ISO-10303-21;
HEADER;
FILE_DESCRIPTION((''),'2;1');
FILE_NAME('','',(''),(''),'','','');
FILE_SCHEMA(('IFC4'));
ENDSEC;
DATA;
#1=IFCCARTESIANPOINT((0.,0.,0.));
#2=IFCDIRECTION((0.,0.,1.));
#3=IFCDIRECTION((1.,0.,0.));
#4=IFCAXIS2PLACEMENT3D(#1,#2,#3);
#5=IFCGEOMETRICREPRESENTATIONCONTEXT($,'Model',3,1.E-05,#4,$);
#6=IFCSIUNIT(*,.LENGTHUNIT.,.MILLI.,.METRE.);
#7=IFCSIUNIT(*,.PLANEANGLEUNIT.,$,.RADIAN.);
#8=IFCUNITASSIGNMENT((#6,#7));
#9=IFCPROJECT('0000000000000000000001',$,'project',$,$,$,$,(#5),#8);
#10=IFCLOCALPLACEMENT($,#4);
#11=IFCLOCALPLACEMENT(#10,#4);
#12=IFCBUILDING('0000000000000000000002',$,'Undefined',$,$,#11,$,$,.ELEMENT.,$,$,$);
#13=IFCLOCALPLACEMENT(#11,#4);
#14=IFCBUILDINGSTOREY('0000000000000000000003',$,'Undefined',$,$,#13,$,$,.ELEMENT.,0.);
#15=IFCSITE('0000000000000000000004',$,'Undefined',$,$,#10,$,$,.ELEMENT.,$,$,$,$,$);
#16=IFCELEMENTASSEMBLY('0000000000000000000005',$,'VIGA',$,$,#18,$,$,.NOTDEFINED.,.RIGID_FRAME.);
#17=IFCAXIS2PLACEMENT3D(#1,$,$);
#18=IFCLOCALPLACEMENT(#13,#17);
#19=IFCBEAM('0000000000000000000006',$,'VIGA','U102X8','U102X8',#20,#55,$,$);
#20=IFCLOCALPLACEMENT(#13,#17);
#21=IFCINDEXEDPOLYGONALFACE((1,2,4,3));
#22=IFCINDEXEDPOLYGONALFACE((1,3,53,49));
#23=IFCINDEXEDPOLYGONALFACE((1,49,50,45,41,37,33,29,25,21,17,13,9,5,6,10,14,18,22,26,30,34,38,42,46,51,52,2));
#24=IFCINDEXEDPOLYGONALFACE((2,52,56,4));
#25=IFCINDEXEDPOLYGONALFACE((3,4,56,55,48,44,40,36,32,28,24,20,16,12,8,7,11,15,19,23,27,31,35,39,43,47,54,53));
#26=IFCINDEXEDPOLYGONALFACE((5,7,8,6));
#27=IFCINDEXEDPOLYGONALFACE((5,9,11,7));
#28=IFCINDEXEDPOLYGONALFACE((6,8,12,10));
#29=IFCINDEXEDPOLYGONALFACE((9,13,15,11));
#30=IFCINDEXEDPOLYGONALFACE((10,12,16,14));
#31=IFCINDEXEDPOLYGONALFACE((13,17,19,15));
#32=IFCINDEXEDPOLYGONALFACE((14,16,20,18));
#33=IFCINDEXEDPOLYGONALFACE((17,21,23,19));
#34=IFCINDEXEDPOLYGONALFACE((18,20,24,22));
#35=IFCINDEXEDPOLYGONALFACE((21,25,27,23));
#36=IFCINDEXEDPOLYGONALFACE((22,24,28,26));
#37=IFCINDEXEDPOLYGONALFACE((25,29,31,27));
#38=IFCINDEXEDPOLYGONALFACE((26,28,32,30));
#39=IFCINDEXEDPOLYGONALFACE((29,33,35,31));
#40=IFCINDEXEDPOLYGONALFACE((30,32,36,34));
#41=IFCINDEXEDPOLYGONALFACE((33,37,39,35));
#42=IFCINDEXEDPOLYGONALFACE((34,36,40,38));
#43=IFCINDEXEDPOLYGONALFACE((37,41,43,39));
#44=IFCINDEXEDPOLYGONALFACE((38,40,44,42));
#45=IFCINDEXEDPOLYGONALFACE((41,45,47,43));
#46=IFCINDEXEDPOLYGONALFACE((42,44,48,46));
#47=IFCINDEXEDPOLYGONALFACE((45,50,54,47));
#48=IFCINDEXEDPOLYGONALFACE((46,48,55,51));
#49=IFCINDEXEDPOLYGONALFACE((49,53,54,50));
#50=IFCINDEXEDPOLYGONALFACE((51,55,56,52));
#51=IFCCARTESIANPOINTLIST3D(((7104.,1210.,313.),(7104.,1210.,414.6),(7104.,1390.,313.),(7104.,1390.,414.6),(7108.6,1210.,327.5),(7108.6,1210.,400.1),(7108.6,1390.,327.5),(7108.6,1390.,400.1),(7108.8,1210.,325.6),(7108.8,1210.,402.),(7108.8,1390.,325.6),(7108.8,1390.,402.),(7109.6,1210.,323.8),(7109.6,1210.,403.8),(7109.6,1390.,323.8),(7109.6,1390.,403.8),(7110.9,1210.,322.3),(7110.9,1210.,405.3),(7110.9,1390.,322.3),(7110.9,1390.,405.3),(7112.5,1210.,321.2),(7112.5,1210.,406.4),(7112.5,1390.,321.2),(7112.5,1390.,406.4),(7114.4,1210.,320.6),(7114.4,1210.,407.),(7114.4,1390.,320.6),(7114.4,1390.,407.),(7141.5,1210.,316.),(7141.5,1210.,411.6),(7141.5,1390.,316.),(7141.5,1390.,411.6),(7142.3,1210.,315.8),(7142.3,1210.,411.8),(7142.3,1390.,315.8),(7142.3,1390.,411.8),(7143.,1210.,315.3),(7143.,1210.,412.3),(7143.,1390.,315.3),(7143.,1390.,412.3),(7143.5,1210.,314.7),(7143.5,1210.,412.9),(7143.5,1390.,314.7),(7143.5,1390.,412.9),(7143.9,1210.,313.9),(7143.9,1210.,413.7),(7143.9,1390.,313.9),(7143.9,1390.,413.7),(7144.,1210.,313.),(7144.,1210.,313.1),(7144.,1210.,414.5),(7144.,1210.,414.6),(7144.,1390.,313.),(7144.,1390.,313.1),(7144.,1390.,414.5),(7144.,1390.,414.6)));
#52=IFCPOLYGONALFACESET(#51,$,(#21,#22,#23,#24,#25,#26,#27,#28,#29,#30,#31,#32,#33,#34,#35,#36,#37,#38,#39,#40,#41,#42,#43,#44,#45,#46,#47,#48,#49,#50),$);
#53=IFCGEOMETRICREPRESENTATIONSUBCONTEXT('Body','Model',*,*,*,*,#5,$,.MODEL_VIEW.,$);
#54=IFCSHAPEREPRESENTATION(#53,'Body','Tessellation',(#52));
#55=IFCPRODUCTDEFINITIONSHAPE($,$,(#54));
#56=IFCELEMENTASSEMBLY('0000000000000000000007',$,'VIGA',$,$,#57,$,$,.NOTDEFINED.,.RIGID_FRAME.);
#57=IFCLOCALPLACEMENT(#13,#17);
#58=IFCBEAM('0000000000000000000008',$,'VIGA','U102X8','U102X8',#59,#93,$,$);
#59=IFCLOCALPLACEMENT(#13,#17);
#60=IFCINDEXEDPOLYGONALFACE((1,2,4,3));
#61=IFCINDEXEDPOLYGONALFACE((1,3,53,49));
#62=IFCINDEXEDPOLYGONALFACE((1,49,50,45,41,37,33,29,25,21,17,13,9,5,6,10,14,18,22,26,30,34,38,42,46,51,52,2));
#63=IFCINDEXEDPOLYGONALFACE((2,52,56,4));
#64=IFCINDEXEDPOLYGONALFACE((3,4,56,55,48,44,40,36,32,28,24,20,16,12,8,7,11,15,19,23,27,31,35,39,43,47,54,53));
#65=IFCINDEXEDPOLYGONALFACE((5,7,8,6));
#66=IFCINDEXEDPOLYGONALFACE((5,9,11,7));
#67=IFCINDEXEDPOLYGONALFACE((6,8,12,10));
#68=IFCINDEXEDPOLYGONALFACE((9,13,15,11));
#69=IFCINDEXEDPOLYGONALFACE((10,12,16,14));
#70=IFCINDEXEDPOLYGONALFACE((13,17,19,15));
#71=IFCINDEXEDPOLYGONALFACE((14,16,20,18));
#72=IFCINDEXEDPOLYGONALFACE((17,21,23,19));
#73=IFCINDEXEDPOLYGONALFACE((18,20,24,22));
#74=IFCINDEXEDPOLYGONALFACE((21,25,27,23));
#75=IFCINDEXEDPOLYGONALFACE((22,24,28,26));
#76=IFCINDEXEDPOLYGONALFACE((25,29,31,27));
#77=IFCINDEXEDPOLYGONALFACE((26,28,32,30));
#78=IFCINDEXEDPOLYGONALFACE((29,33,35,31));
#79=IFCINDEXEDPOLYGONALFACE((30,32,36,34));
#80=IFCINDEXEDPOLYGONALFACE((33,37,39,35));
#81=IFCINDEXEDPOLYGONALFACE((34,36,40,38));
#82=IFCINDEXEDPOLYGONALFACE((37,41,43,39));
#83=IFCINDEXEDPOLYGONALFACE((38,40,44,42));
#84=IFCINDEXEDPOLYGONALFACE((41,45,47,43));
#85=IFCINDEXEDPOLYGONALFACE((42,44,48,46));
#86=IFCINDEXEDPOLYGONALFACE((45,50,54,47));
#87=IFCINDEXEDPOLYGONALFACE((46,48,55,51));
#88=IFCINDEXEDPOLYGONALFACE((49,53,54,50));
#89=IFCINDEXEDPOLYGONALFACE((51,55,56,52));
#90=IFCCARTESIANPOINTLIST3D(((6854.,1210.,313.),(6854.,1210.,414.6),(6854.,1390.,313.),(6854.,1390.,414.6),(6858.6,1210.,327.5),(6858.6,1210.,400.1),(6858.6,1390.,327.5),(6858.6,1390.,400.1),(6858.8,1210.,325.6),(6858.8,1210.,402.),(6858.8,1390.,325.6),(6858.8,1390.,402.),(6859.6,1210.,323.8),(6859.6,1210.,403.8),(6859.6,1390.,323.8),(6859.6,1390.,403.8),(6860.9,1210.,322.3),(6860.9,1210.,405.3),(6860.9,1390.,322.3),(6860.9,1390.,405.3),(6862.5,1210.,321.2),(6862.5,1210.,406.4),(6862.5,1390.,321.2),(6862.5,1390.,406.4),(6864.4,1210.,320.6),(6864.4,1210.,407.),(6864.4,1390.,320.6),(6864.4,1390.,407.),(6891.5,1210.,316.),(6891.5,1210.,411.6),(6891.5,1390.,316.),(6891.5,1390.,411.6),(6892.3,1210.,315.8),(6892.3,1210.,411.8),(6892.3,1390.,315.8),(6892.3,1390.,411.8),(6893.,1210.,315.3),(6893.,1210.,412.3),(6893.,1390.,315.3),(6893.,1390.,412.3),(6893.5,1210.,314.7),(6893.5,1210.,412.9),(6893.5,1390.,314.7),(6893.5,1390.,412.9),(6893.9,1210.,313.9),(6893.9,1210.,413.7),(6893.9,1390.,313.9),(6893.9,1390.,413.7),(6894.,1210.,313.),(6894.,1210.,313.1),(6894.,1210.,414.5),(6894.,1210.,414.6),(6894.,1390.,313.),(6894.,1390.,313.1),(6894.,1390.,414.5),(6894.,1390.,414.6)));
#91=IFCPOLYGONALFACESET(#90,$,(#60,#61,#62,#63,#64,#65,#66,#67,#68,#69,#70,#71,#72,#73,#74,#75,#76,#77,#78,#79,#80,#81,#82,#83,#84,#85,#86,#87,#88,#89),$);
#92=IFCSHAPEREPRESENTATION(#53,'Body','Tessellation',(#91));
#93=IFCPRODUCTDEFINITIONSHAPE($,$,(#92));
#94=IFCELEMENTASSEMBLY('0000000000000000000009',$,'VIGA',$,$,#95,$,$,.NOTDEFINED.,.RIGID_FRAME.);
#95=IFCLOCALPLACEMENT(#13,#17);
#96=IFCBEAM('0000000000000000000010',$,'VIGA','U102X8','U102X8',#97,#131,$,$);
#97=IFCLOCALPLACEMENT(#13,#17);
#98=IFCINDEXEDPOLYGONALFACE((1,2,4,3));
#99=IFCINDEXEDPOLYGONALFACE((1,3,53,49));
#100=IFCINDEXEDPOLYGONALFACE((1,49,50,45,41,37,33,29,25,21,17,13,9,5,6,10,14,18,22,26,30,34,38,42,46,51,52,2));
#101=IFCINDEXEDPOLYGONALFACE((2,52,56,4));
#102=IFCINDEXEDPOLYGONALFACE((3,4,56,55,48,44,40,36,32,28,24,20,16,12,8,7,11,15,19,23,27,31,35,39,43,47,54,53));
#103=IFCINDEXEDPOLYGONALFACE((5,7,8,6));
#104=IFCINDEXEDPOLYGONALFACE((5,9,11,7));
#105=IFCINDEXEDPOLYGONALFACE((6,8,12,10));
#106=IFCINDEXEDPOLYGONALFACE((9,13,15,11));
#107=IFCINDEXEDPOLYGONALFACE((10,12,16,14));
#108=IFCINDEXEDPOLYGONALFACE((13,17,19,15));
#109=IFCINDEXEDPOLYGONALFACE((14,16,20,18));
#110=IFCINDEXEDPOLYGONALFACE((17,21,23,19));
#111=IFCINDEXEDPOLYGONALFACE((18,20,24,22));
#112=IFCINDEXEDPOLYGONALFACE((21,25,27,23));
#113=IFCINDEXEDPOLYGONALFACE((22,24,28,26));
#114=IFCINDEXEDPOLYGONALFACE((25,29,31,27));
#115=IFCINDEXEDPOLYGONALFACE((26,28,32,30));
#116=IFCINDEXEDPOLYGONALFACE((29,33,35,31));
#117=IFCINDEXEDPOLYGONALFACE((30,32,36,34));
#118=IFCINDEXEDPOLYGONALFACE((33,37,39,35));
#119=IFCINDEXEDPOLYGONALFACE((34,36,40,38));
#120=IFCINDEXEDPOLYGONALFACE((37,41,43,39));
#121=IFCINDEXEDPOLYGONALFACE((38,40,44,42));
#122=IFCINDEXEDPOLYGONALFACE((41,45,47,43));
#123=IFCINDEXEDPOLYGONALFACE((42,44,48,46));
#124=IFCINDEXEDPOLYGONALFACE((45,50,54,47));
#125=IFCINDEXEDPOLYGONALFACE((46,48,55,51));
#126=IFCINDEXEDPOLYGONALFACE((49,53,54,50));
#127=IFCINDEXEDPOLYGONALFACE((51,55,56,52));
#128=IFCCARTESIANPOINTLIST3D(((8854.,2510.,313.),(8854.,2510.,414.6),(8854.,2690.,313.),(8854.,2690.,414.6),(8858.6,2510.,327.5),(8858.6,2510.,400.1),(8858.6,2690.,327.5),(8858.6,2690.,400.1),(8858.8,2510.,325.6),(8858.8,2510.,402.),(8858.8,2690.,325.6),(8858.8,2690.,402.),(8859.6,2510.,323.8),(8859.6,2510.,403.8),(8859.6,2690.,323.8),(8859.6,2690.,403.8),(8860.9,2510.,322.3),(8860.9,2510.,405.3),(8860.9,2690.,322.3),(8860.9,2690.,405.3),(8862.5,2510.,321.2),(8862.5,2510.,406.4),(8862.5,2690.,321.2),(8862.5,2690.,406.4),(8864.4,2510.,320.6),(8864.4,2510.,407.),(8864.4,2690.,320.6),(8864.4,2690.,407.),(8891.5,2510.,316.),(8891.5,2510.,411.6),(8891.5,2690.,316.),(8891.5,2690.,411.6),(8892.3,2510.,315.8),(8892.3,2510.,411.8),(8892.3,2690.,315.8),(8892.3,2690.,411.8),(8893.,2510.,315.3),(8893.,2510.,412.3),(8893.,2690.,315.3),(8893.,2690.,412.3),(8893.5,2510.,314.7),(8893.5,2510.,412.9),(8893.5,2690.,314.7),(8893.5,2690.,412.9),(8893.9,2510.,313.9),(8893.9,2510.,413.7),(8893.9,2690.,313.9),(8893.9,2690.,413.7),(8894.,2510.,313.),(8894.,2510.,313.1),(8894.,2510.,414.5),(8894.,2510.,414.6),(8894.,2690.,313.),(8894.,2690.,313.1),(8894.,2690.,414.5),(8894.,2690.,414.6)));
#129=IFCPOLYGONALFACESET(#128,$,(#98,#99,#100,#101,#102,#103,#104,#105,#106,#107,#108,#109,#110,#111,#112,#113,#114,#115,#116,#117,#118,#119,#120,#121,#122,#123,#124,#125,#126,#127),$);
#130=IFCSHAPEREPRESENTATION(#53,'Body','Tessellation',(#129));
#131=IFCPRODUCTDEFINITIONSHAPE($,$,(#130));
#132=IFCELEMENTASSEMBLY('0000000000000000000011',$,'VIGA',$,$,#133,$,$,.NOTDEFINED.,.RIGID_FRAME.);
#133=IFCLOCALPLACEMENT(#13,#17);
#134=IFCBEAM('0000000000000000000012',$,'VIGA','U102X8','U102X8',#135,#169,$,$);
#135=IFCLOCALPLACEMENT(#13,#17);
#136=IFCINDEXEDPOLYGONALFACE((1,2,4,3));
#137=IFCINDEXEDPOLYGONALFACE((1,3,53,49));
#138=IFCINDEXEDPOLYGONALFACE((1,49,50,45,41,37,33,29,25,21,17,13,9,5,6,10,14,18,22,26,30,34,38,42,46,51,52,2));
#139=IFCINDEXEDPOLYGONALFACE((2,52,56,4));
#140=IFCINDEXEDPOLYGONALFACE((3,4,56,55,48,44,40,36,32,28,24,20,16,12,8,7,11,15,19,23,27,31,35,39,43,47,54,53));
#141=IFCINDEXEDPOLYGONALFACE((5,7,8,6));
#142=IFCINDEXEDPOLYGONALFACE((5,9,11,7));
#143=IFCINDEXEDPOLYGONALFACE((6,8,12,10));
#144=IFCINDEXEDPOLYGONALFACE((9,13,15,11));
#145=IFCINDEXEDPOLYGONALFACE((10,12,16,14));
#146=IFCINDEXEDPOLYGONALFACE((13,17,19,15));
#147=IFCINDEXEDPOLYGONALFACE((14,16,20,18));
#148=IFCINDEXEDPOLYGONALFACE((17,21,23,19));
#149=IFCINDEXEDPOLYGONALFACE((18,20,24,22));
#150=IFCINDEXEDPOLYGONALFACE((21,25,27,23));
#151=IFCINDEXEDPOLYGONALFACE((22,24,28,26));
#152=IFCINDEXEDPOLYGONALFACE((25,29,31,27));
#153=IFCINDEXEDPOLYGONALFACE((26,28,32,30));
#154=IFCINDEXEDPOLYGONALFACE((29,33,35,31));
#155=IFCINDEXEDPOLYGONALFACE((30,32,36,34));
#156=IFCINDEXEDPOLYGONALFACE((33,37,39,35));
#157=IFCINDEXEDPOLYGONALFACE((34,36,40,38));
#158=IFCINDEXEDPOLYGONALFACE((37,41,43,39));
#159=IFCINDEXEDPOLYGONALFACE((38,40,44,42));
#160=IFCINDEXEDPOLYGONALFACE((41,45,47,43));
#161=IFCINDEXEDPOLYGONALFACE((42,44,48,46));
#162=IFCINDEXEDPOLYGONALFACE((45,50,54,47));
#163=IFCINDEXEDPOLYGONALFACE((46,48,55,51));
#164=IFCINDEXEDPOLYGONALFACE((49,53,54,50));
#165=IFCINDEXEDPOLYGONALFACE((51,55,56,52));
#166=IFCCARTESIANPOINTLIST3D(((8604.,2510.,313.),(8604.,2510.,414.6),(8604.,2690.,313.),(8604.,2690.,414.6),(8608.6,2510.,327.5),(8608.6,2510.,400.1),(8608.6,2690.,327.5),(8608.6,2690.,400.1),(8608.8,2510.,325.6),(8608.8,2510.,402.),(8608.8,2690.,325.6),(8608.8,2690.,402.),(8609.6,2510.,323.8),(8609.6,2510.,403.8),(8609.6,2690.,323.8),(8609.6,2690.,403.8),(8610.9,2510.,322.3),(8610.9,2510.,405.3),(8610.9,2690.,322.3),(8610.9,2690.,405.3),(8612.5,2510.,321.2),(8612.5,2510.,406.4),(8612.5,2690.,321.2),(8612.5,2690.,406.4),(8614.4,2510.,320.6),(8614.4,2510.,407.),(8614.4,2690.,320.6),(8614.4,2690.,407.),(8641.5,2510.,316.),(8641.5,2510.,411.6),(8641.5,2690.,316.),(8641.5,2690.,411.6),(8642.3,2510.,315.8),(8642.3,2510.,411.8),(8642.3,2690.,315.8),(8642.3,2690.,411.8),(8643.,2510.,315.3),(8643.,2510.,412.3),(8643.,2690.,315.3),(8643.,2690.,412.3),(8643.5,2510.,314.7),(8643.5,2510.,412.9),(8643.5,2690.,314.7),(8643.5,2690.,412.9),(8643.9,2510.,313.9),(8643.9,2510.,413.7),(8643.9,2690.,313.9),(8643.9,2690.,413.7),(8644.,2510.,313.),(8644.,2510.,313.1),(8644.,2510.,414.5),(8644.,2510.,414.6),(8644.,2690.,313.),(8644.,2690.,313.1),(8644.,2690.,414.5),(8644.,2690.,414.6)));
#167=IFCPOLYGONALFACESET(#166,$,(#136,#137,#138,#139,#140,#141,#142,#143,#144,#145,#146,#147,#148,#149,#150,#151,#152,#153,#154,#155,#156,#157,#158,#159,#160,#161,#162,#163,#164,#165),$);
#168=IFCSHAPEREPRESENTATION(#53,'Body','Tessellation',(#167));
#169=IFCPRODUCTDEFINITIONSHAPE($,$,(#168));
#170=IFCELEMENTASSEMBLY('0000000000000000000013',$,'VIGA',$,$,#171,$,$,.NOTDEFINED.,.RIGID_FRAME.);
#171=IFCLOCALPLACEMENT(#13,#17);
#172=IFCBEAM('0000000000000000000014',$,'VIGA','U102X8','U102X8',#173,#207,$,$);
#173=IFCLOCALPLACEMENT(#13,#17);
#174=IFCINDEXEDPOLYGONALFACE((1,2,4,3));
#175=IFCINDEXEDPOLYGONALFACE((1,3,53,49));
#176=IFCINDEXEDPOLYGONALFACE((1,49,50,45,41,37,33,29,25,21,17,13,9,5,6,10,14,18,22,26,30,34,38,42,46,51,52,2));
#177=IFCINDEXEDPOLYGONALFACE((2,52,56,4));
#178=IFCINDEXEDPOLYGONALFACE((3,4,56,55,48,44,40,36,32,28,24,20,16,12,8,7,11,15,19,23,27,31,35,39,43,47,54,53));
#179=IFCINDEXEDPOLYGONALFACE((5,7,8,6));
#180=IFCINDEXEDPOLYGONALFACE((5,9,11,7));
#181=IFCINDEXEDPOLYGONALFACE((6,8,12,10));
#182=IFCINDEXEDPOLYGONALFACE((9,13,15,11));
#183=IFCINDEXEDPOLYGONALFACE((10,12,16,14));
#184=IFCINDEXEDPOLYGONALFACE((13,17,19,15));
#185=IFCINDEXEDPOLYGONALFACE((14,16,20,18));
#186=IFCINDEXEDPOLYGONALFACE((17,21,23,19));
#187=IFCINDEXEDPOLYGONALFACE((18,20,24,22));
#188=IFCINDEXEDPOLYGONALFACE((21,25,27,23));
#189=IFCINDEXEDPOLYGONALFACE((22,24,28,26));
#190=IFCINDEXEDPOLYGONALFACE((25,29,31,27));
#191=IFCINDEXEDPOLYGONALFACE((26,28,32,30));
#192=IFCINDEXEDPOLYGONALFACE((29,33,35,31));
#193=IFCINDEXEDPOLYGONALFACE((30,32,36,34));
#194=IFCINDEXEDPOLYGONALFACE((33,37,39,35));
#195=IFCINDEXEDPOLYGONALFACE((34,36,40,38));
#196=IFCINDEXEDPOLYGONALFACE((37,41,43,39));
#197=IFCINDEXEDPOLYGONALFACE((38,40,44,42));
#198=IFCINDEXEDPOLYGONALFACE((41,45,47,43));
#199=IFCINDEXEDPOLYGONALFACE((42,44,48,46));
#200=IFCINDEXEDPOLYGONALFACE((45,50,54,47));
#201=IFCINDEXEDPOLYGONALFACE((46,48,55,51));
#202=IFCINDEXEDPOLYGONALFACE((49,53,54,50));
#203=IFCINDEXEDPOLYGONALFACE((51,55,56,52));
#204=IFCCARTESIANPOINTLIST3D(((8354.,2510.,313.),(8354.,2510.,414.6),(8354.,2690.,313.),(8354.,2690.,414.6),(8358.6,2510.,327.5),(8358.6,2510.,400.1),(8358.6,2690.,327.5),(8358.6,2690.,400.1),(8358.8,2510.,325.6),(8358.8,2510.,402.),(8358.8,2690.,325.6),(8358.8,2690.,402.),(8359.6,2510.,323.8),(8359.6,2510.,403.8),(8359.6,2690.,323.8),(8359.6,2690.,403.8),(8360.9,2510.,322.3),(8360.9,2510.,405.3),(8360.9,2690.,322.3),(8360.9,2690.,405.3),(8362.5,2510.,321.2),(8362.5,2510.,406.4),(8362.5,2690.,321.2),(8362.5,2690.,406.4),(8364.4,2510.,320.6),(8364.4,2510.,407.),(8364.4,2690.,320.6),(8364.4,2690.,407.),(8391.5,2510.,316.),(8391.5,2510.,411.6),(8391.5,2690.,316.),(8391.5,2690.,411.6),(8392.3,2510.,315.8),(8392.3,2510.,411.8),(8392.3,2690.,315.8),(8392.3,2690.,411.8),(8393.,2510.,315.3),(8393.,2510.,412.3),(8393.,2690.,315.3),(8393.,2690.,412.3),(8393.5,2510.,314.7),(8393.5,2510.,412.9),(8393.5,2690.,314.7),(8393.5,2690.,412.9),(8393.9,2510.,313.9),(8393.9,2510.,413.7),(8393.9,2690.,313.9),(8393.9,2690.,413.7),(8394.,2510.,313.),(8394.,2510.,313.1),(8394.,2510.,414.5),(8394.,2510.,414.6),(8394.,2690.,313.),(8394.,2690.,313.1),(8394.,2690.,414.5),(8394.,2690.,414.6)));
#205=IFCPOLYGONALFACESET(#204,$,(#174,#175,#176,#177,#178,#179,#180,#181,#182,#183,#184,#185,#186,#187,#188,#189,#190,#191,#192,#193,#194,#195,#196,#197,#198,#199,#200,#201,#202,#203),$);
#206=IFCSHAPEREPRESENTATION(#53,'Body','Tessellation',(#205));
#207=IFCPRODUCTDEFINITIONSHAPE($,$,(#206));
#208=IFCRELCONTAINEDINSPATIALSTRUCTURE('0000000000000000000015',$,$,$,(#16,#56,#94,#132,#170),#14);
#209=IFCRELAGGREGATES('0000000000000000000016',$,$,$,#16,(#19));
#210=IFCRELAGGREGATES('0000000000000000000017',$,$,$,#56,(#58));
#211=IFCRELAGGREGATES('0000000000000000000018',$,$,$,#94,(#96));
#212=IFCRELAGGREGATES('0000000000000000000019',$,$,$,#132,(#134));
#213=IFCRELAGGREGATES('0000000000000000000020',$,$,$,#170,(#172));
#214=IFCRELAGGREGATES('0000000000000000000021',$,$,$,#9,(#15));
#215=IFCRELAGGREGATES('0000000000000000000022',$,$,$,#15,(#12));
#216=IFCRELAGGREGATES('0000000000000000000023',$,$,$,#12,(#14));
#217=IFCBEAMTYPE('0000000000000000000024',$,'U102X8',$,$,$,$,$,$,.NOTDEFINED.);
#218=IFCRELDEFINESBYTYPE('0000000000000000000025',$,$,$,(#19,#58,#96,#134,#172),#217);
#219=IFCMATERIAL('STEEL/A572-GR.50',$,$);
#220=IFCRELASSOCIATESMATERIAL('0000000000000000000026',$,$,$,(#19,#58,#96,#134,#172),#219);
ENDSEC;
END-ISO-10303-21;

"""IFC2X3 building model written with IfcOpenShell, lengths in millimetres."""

from ifc_helpers import new_model, si_unit, frame, origin_with_axes, origin_2d_with_axis, place, context, subcontext, project, spatial, u_section, extrude, material, type_object, element, aggregate, save


model = new_model("IFC2X3")

# Units and contexts
model_context = context("Model", 3, precision=1e-05, world=origin_with_axes())
body_context = subcontext(model_context, "Body", "Model", "MODEL_VIEW")
ifc_project = project(units=[si_unit("LENGTHUNIT", "METRE", prefix="MILLI"), si_unit("PLANEANGLEUNIT", "RADIAN")], contexts=[model_context])

# Site, building, storey
site_placement = place(None, origin_with_axes())
site = spatial("IfcSite", under=ifc_project, at=site_placement, Name="Undefined", CompositionType="ELEMENT")
building_placement = place(site_placement, origin_with_axes())
building = spatial("IfcBuilding", under=site, at=building_placement, Name="Undefined", CompositionType="ELEMENT")
storey_placement = place(building_placement, origin_with_axes())
storey = spatial("IfcBuildingStorey", under=building, at=storey_placement, Name="Undefined", CompositionType="ELEMENT", Elevation=0.0)

# Element assemblies, beams
ifc_material_1 = material(Name="STEEL/A572-GR.50")
beam_type_1 = type_object("IfcBeamType", Name="U102X8", PredefinedType="NOTDEFINED")
assembly_1_placement = place(storey_placement, origin_with_axes())
assembly_1 = element("IfcElementAssembly", 1, at=assembly_1_placement, inside=storey, Name="VIGA", AssemblyPlace="NOTDEFINED", PredefinedType="RIGID_FRAME")
beam_1_placement = place(assembly_1_placement, frame((7124.0, 1210.0, 363.8), z_axis=(0.0, 0.0, 1.0), x_axis=(0.0, 1.0, 0.0)))
beam_1 = element("IfcBeam", 2, at=beam_1_placement, type_object=beam_type_1, material=ifc_material_1, Name="VIGA", Description="U102X8", ObjectType="U102X8", context=body_context, shape_type="SweptSolid", body=[
    extrude(u_section(Depth=101.6, FlangeWidth=40.0, WebThickness=4.6, FlangeThickness=6.0, FilletRadius=7.0, EdgeRadius=3.0, FlangeSlope=0.16839, at=origin_2d_with_axis()), frame((180.0, 0.0, 0.0), z_axis=(-1.0, 0.0, 0.0), x_axis=(0.0, -1.0, 0.0)), (0.0, 0.0, 1.0), 180.0),
])
aggregate(assembly_1, [beam_1])
assembly_2_placement = place(storey_placement, origin_with_axes())
assembly_2 = element("IfcElementAssembly", 3, at=assembly_2_placement, inside=storey, Name="VIGA", AssemblyPlace="NOTDEFINED", PredefinedType="RIGID_FRAME")
beam_2_placement = place(assembly_2_placement, frame((6874.0, 1210.0, 363.8), z_axis=(0.0, 0.0, 1.0), x_axis=(0.0, 1.0, 0.0)))
beam_2 = element("IfcBeam", 4, at=beam_2_placement, type_object=beam_type_1, material=ifc_material_1, Name="VIGA", Description="U102X8", ObjectType="U102X8", context=body_context, shape_type="SweptSolid", body=[
    extrude(u_section(Depth=101.6, FlangeWidth=40.0, WebThickness=4.6, FlangeThickness=6.0, FilletRadius=7.0, EdgeRadius=3.0, FlangeSlope=0.16839, at=origin_2d_with_axis()), frame((180.0, 0.0, 0.0), z_axis=(-1.0, 0.0, 0.0), x_axis=(0.0, -1.0, 0.0)), (0.0, 0.0, 1.0), 180.0),
])
aggregate(assembly_2, [beam_2])
assembly_3_placement = place(storey_placement, origin_with_axes())
assembly_3 = element("IfcElementAssembly", 5, at=assembly_3_placement, inside=storey, Name="VIGA", AssemblyPlace="NOTDEFINED", PredefinedType="RIGID_FRAME")
beam_3_placement = place(assembly_3_placement, frame((8874.0, 2510.0, 363.8), z_axis=(0.0, 0.0, 1.0), x_axis=(0.0, 1.0, 0.0)))
beam_3 = element("IfcBeam", 6, at=beam_3_placement, type_object=beam_type_1, material=ifc_material_1, Name="VIGA", Description="U102X8", ObjectType="U102X8", context=body_context, shape_type="SweptSolid", body=[
    extrude(u_section(Depth=101.6, FlangeWidth=40.0, WebThickness=4.6, FlangeThickness=6.0, FilletRadius=7.0, EdgeRadius=3.0, FlangeSlope=0.16839, at=origin_2d_with_axis()), frame((180.0, 0.0, 0.0), z_axis=(-1.0, 0.0, 0.0), x_axis=(0.0, -1.0, 0.0)), (0.0, 0.0, 1.0), 180.0),
])
aggregate(assembly_3, [beam_3])
assembly_4_placement = place(storey_placement, origin_with_axes())
assembly_4 = element("IfcElementAssembly", 7, at=assembly_4_placement, inside=storey, Name="VIGA", AssemblyPlace="NOTDEFINED", PredefinedType="RIGID_FRAME")
beam_4_placement = place(assembly_4_placement, frame((8624.0, 2510.0, 363.8), z_axis=(0.0, 0.0, 1.0), x_axis=(0.0, 1.0, 0.0)))
beam_4 = element("IfcBeam", 8, at=beam_4_placement, type_object=beam_type_1, material=ifc_material_1, Name="VIGA", Description="U102X8", ObjectType="U102X8", context=body_context, shape_type="SweptSolid", body=[
    extrude(u_section(Depth=101.6, FlangeWidth=40.0, WebThickness=4.6, FlangeThickness=6.0, FilletRadius=7.0, EdgeRadius=3.0, FlangeSlope=0.16839, at=origin_2d_with_axis()), frame((180.0, 0.0, 0.0), z_axis=(-1.0, 0.0, 0.0), x_axis=(0.0, -1.0, 0.0)), (0.0, 0.0, 1.0), 180.0),
])
aggregate(assembly_4, [beam_4])
assembly_5_placement = place(storey_placement, origin_with_axes())
assembly_5 = element("IfcElementAssembly", 9, at=assembly_5_placement, inside=storey, Name="VIGA", AssemblyPlace="NOTDEFINED", PredefinedType="RIGID_FRAME")
beam_5_placement = place(assembly_5_placement, frame((8374.0, 2510.0, 363.8), z_axis=(0.0, 0.0, 1.0), x_axis=(0.0, 1.0, 0.0)))
beam_5 = element("IfcBeam", 10, at=beam_5_placement, type_object=beam_type_1, material=ifc_material_1, Name="VIGA", Description="U102X8", ObjectType="U102X8", context=body_context, shape_type="SweptSolid", body=[
    extrude(u_section(Depth=101.6, FlangeWidth=40.0, WebThickness=4.6, FlangeThickness=6.0, FilletRadius=7.0, EdgeRadius=3.0, FlangeSlope=0.16839, at=origin_2d_with_axis()), frame((180.0, 0.0, 0.0), z_axis=(-1.0, 0.0, 0.0), x_axis=(0.0, -1.0, 0.0)), (0.0, 0.0, 1.0), 180.0),
])
aggregate(assembly_5, [beam_5])

save(model, "model.ifc")
